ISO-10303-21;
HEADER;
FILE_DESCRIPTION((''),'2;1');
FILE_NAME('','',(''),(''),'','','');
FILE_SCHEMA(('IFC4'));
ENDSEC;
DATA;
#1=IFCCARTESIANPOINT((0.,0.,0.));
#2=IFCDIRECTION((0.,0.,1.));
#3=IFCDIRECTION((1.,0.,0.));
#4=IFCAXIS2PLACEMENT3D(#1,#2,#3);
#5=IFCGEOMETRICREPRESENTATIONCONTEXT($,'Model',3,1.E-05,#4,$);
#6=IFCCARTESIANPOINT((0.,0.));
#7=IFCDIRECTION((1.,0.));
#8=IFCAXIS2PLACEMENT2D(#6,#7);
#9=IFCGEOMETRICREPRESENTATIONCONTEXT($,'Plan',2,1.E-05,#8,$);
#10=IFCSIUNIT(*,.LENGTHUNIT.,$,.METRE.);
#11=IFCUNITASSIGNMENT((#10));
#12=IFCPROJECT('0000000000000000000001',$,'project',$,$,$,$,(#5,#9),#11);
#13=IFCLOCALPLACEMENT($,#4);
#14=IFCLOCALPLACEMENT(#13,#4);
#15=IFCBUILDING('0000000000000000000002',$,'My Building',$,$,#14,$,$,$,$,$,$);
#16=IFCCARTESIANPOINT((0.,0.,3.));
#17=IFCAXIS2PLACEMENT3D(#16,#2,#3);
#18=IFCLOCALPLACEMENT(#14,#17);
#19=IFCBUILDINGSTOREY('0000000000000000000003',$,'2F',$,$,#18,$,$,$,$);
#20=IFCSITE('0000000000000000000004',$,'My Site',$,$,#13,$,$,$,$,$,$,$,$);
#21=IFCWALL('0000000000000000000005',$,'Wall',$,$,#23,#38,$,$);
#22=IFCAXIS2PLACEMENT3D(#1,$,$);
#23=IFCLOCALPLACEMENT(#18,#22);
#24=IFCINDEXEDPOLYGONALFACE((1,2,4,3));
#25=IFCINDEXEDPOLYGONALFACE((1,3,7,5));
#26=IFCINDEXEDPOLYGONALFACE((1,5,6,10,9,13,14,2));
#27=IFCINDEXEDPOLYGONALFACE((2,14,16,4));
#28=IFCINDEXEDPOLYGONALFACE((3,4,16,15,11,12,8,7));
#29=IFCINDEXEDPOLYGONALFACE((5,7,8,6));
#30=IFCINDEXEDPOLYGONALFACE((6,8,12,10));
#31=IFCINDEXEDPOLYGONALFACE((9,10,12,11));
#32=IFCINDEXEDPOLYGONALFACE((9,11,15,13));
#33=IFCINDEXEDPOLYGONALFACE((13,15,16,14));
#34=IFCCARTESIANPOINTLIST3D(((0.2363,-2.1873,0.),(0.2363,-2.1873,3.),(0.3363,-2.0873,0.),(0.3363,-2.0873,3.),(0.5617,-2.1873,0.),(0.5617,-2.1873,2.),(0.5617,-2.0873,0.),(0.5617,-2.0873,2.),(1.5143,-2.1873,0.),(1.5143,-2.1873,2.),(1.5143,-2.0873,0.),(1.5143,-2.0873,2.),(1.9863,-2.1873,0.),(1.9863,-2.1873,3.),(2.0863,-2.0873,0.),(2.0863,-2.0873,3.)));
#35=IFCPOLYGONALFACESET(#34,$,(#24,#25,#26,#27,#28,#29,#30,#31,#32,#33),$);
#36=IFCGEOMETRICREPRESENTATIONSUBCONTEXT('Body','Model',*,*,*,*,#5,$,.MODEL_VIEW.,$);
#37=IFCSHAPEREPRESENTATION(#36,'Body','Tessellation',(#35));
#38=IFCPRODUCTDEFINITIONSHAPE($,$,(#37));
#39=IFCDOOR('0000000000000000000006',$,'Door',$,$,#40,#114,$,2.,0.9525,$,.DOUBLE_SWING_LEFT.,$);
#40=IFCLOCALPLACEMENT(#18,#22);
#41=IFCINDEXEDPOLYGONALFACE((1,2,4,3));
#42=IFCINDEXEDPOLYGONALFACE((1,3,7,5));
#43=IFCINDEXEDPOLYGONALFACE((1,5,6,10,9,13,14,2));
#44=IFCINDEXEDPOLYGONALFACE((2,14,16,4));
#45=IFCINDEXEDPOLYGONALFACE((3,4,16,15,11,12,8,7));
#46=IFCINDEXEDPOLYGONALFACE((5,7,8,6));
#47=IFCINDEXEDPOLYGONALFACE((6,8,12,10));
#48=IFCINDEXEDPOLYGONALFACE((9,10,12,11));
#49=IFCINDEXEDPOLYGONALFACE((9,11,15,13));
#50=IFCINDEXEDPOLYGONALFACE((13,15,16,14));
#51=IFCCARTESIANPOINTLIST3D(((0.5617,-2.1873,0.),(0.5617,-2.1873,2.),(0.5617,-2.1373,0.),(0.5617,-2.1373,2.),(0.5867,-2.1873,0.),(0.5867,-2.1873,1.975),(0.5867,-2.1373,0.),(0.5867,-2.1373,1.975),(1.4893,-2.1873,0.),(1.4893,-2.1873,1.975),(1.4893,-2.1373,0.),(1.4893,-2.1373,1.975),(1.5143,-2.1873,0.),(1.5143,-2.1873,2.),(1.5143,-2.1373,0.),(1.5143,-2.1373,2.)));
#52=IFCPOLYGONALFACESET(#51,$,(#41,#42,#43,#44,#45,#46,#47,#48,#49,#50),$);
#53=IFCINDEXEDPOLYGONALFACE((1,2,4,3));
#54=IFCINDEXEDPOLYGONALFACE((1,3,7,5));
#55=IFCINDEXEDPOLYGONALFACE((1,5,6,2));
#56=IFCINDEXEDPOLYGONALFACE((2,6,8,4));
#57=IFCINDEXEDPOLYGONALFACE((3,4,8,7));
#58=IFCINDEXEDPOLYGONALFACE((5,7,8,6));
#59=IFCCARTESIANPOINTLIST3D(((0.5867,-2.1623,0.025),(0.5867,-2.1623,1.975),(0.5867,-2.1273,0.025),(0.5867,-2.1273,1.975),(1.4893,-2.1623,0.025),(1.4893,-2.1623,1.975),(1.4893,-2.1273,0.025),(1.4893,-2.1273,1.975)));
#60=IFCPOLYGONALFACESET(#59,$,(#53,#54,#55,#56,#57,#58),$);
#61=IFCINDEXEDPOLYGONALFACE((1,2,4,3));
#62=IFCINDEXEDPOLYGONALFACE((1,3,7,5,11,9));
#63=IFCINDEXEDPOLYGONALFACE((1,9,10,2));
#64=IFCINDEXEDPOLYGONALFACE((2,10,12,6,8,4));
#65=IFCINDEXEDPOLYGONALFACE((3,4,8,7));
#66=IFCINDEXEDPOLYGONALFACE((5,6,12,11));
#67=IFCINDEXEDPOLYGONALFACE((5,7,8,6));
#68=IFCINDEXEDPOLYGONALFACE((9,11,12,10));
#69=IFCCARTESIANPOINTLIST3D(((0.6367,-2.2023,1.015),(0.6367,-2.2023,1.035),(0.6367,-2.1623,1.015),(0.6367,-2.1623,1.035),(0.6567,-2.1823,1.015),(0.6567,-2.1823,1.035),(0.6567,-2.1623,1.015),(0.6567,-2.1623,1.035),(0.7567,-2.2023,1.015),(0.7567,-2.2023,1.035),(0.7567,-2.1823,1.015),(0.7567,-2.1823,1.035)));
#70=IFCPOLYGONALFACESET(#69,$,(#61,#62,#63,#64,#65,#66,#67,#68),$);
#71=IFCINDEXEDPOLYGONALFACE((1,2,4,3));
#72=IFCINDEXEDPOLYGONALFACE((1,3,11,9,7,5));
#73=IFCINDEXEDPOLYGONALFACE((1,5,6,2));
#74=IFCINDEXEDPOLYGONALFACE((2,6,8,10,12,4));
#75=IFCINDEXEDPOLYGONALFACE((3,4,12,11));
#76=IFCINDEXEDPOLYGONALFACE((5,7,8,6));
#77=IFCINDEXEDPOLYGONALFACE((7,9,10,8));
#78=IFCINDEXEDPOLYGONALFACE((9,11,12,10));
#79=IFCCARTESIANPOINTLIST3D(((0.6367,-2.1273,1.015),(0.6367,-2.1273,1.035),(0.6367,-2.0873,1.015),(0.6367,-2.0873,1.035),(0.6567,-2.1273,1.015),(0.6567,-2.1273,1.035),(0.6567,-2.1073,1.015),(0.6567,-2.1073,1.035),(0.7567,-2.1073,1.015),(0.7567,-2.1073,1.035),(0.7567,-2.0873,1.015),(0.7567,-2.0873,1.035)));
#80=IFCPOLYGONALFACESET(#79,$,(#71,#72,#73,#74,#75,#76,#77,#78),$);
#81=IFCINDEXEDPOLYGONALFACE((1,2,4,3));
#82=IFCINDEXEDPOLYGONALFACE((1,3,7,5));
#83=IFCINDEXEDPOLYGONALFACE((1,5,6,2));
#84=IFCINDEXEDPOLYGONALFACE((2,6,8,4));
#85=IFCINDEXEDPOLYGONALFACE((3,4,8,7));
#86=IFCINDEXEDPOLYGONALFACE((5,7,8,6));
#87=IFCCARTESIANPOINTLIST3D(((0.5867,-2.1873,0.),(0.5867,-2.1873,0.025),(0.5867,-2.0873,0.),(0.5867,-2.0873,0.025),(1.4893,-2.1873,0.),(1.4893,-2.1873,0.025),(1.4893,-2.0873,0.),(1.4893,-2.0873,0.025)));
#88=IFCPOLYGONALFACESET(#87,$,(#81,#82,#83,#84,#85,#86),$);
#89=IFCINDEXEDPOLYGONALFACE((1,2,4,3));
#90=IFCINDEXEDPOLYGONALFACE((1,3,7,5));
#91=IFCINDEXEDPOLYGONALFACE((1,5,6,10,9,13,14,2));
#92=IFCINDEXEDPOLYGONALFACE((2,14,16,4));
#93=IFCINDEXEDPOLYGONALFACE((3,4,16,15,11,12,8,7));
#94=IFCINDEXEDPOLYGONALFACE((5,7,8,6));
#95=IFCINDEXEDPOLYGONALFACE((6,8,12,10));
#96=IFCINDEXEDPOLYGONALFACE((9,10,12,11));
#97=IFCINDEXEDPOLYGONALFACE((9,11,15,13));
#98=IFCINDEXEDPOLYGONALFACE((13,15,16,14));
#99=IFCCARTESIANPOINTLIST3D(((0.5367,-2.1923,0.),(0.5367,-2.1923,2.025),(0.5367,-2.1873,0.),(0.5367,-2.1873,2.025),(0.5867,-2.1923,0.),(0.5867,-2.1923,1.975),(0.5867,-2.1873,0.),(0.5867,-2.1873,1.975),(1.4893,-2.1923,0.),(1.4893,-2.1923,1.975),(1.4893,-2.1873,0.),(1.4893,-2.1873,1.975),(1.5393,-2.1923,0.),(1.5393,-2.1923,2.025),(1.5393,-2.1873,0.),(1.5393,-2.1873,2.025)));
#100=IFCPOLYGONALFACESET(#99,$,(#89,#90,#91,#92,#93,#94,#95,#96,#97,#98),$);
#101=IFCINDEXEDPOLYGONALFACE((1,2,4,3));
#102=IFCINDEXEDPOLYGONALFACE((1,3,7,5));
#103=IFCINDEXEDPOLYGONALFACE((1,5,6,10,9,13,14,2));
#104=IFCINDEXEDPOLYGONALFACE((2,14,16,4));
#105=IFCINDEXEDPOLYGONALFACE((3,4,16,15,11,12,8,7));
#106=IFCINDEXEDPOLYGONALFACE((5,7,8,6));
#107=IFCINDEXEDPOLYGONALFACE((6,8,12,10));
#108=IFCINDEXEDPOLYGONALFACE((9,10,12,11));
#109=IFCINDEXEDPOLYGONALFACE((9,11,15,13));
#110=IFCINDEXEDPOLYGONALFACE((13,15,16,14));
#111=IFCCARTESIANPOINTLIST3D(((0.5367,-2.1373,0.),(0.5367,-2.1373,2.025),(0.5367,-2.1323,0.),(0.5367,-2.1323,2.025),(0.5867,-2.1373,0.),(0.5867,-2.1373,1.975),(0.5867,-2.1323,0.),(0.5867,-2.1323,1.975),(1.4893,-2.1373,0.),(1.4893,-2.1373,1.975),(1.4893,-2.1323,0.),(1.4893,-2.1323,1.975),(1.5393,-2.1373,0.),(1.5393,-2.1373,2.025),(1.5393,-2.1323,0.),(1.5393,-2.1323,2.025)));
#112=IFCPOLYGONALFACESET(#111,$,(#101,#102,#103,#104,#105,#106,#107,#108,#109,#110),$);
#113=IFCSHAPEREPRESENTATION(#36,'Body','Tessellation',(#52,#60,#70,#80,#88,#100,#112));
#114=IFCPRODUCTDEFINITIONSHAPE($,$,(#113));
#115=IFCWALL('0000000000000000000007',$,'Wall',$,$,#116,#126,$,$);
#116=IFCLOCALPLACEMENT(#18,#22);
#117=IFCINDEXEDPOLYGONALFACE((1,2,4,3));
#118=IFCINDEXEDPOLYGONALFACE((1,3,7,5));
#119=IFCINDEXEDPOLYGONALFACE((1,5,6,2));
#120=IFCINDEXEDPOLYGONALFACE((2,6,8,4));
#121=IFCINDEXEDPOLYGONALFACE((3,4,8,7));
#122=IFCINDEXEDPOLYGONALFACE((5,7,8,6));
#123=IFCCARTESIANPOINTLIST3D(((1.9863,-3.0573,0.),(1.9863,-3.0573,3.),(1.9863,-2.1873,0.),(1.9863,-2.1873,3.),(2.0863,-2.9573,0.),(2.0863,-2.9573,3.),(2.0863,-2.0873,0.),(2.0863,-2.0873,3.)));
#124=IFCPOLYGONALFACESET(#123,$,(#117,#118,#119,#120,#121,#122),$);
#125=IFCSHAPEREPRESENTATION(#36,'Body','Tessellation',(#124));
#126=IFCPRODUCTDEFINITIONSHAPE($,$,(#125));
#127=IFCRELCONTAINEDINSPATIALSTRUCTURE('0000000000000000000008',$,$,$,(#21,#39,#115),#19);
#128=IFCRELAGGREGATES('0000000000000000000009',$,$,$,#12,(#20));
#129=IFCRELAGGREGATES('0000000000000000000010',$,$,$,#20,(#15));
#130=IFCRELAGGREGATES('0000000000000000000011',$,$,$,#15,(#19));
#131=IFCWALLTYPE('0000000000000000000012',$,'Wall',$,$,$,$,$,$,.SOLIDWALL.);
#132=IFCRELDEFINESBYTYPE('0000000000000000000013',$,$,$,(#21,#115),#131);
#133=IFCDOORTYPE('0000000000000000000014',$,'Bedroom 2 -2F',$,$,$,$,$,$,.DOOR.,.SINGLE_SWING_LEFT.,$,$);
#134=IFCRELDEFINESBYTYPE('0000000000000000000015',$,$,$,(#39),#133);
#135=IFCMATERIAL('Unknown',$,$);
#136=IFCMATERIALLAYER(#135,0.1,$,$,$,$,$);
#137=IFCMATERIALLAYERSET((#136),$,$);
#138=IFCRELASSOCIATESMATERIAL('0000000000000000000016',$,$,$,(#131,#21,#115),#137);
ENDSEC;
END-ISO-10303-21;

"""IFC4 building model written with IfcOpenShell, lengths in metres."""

from ifc_helpers import new_model, entity, si_unit, frame, origin_with_axes, origin_2d_with_axis, place, context, subcontext, project, spatial, line, indexed_curve, outline, extrude, shape, source, transform, mapped, material, layer, layer_set, layer_usage, type_object, type_shapes, element, fill, save


model = new_model("IFC4")

# Units and contexts
model_context = context("Model", 3, precision=1e-05, world=origin_with_axes())
plan_context = context("Plan", 2, precision=1e-05, world=origin_2d_with_axis())
body_context_1 = subcontext(model_context, "Body", "Model", "MODEL_VIEW")
body_context_2 = subcontext(plan_context, "Body", "Plan", "PLAN_VIEW")
ifc_project = project(units=[si_unit("LENGTHUNIT", "METRE")], contexts=[model_context, plan_context])

# Site, building, storey
site_placement = place(None, origin_with_axes())
site = spatial("IfcSite", under=ifc_project, at=site_placement, Name="My Site")
building_placement = place(site_placement, origin_with_axes())
building = spatial("IfcBuilding", under=site, at=building_placement, Name="My Building")
storey_placement = place(building_placement, frame((0.0, 0.0, 3.0), z_axis=(0.0, 0.0, 1.0), x_axis=(1.0, 0.0, 0.0)))
storey = spatial("IfcBuildingStorey", under=building, at=storey_placement, Name="2F")

# Shared definitions
ifc_material = material(Name="Unknown")

# Shared definitions
ifc_layer_1 = layer(ifc_material, 0.1)
ifc_layer_set_1 = layer_set([ifc_layer_1])
wall_type = type_object("IfcWallType", Name="Wall", PredefinedType="SOLIDWALL", material=ifc_layer_set_1)

# Wall, opening, door
ifc_layer_usage_1 = layer_usage(ifc_layer_set_1, "AXIS2", "POSITIVE", 0.0)
wall_1_placement = place(storey_placement, frame((0.2363, -2.1873, 0.0), z_axis=(0.0, 0.0, 1.0), x_axis=(1.0, 0.0, 0.0)))
wall_1 = element("IfcWall", 1, at=wall_1_placement, inside=storey, type_object=wall_type, material=ifc_layer_usage_1, Name="Wall", context=body_context_1, shape_type="SweptSolid", body=[
    extrude(outline(indexed_curve([(0.0, 0.0), (0.1, 0.1), (1.85, 0.1), (1.75, 0.0)], segments=[line(1, 2, 3, 4, 1)])), origin_with_axes(), (0.0, 0.0, 1.0), 3.0),
])
shared_shape_1 = source(origin_with_axes(), body_context_1, "Body", "SweptSolid", [
    extrude(outline(indexed_curve([(0.0, 0.0), (0.9525, 0.0), (0.9525, 2.0), (0.0, 2.0)], segments=[line(1, 2, 3, 4, 1)])), frame((0.0, -0.6, 0.0), z_axis=(0.0, -1.0, 0.0), x_axis=(1.0, 0.0, 0.0)), (0.0, 0.0, -1.0), 1.2),
])
opening_1_placement = place(wall_1_placement, frame((0.3254, 0.0, 0.0), z_axis=(0.0, 0.0, 1.0), x_axis=(1.0, 0.0, 0.0)))
opening_1 = element("IfcOpeningElement", 2, at=opening_1_placement, cuts=wall_1, PredefinedType="OPENING", context=body_context_1, shape_type="MappedRepresentation", body=[
    mapped(shared_shape_1, transform((0.0, 0.0, 0.0), x_axis=(1.0, 0.0, 0.0), y_axis=(0.0, 1.0, 0.0), z_axis=(0.0, 0.0, 1.0), scale=1.0)),
])
door_type_1 = type_object("IfcDoorType", Name="Bedroom 2 -2F", OperationType="SINGLE_SWING_LEFT", PredefinedType="DOOR")
shared_shape_2 = source(origin_with_axes(), body_context_1, "Body", "SweptSolid", [
    extrude(outline(indexed_curve([(0.0, 0.0), (0.0, 2.0), (0.9525, 2.0), (0.9525, 0.0), (0.9275, 0.0), (0.9275, 1.975), (0.025, 1.975), (0.025, 0.0)], segments=[line(1, 2, 3, 4, 5, 6, 7, 8, 1)])), frame((0.0, 0.0, 0.0), z_axis=(0.0, -1.0, 0.0), x_axis=(1.0, 0.0, 0.0)), (0.0, 0.0, -1.0), 0.05),
    extrude(outline(indexed_curve([(0.0, 0.0), (0.9025, 0.0), (0.9025, 0.035), (0.0, 0.035)], segments=[line(1, 2, 3, 4, 1)])), frame((0.025, 0.025, 0.025), z_axis=(0.0, 0.0, 1.0), x_axis=(1.0, 0.0, 0.0)), (0.0, 0.0, 1.0), 1.95),
    extrude(outline(indexed_curve([(0.0, 0.0), (0.0, -0.04), (0.12, -0.04), (0.12, -0.02), (0.02, -0.02), (0.02, 0.0)], segments=[line(1, 2, 3, 4, 5, 6, 1)])), frame((0.075, 0.025, 1.015), z_axis=(0.0, 0.0, 1.0), x_axis=(1.0, 0.0, 0.0)), (0.0, 0.0, 1.0), 0.02),
    extrude(outline(indexed_curve([(0.0, 0.0), (0.0, 0.04), (0.12, 0.04), (0.12, 0.02), (0.02, 0.02), (0.02, 0.0)], segments=[line(1, 2, 3, 4, 5, 6, 1)])), frame((0.075, 0.06, 1.015), z_axis=(0.0, 0.0, 1.0), x_axis=(1.0, 0.0, 0.0)), (0.0, 0.0, 1.0), 0.02),
    extrude(outline(indexed_curve([(0.0, 0.0), (0.9025, 0.0), (0.9025, 0.1), (0.0, 0.1)], segments=[line(1, 2, 3, 4, 1)])), frame((0.025, 0.0, 0.0), z_axis=(0.0, 0.0, 1.0), x_axis=(1.0, 0.0, 0.0)), (0.0, 0.0, 1.0), 0.025),
    extrude(outline(indexed_curve([(0.0, 0.0), (0.0, 2.025), (1.0025, 2.025), (1.0025, 0.0), (0.9525, 0.0), (0.9525, 1.975), (0.05, 1.975), (0.05, 0.0)], segments=[line(1, 2, 3, 4, 5, 6, 7, 8, 1)])), frame((-0.025, -0.005, 0.0), z_axis=(0.0, -1.0, 0.0), x_axis=(1.0, 0.0, 0.0)), (0.0, 0.0, -1.0), 0.005),
    extrude(outline(indexed_curve([(0.0, 0.0), (0.0, 2.025), (1.0025, 2.025), (1.0025, 0.0), (0.9525, 0.0), (0.9525, 1.975), (0.05, 1.975), (0.05, 0.0)], segments=[line(1, 2, 3, 4, 5, 6, 7, 8, 1)])), frame((-0.025, 0.05, 0.0), z_axis=(0.0, -1.0, 0.0), x_axis=(1.0, 0.0, 0.0)), (0.0, 0.0, -1.0), 0.005),
])
shared_shape_3 = source(origin_with_axes(), body_context_2, "Body", "Curve2D", [
    entity("IfcIndexedPolyCurve", entity("IfcCartesianPointList2D", [[0.0, 0.0], [0.025, 0.0], [0.025, 0.05], [0.0, 0.05]]), [entity("IfcLineIndex", [1, 2, 3, 4, 1])]),
    entity("IfcIndexedPolyCurve", entity("IfcCartesianPointList2D", [[0.9525, 0.0], [0.9275, 0.0], [0.9275, 0.05], [0.9525, 0.05]]), [entity("IfcLineIndex", [1, 2, 3, 4, 1])]),
    entity("IfcIndexedPolyCurve", entity("IfcCartesianPointList2D", [[0.9275, 0.05], [0.9275, -0.8525], [0.8925, -0.8525]])),
    entity("IfcTrimmedCurve", entity("IfcEllipse", entity("IfcAxis2Placement2D", entity("IfcCartesianPoint", [0.8925, 0.05]), entity("IfcDirection", [1.0, 0.0])), 0.8675, 0.9025), [entity("IfcCartesianPoint", [0.8925, 0.9525])], [entity("IfcCartesianPoint", [0.8925, -0.8525])], True, "CARTESIAN"),
    entity("IfcIndexedPolyCurve", entity("IfcCartesianPointList2D", [[0.9275, 0.05], [0.8925, 0.05], [0.8925, 0.9525], [0.9275, 0.9525]]), [entity("IfcLineIndex", [1, 2, 3, 4, 1])]),
])
type_shapes(door_type_1, [shared_shape_2, shared_shape_3])
door_1_placement = place(opening_1_placement, origin_with_axes())
door_1 = element("IfcDoor", 3, at=door_1_placement, inside=storey, type_object=door_type_1, Name="Door", OperationType="DOUBLE_SWING_LEFT", OverallHeight=2.0, OverallWidth=0.9525, shapes=[
    shape(body_context_1, "Body", "MappedRepresentation", [mapped(shared_shape_2, transform((0.0, 0.0, 0.0), x_axis=(1.0, 0.0, 0.0), y_axis=(0.0, 1.0, 0.0), z_axis=(0.0, 0.0, 1.0), scale=1.0))]),
    shape(body_context_2, "Body", "MappedRepresentation", [mapped(shared_shape_3, transform((0.0, 0.0, 0.0), x_axis=(1.0, 0.0, 0.0), y_axis=(0.0, 1.0, 0.0), z_axis=(0.0, 0.0, 1.0), scale=1.0))]),
])
fill(opening_1, door_1)

# Wall
ifc_layer_usage_2 = layer_usage(ifc_layer_set_1, "AXIS2", "POSITIVE", 0.0)
wall_2_placement = place(storey_placement, frame((1.9863, -2.1873, 0.0), z_axis=(0.0, 0.0, 1.0), x_axis=(0.0, -1.0, 0.0)))
element("IfcWall", 4, at=wall_2_placement, inside=storey, type_object=wall_type, material=ifc_layer_usage_2, Name="Wall", context=body_context_1, shape_type="SweptSolid", body=[
    extrude(outline(indexed_curve([(0.0, 0.0), (-0.1, 0.1), (0.77, 0.1), (0.87, 0.0)], segments=[line(1, 2, 3, 4, 1)])), origin_with_axes(), (0.0, 0.0, 1.0), 3.0),
])

save(model, "model.ifc")
